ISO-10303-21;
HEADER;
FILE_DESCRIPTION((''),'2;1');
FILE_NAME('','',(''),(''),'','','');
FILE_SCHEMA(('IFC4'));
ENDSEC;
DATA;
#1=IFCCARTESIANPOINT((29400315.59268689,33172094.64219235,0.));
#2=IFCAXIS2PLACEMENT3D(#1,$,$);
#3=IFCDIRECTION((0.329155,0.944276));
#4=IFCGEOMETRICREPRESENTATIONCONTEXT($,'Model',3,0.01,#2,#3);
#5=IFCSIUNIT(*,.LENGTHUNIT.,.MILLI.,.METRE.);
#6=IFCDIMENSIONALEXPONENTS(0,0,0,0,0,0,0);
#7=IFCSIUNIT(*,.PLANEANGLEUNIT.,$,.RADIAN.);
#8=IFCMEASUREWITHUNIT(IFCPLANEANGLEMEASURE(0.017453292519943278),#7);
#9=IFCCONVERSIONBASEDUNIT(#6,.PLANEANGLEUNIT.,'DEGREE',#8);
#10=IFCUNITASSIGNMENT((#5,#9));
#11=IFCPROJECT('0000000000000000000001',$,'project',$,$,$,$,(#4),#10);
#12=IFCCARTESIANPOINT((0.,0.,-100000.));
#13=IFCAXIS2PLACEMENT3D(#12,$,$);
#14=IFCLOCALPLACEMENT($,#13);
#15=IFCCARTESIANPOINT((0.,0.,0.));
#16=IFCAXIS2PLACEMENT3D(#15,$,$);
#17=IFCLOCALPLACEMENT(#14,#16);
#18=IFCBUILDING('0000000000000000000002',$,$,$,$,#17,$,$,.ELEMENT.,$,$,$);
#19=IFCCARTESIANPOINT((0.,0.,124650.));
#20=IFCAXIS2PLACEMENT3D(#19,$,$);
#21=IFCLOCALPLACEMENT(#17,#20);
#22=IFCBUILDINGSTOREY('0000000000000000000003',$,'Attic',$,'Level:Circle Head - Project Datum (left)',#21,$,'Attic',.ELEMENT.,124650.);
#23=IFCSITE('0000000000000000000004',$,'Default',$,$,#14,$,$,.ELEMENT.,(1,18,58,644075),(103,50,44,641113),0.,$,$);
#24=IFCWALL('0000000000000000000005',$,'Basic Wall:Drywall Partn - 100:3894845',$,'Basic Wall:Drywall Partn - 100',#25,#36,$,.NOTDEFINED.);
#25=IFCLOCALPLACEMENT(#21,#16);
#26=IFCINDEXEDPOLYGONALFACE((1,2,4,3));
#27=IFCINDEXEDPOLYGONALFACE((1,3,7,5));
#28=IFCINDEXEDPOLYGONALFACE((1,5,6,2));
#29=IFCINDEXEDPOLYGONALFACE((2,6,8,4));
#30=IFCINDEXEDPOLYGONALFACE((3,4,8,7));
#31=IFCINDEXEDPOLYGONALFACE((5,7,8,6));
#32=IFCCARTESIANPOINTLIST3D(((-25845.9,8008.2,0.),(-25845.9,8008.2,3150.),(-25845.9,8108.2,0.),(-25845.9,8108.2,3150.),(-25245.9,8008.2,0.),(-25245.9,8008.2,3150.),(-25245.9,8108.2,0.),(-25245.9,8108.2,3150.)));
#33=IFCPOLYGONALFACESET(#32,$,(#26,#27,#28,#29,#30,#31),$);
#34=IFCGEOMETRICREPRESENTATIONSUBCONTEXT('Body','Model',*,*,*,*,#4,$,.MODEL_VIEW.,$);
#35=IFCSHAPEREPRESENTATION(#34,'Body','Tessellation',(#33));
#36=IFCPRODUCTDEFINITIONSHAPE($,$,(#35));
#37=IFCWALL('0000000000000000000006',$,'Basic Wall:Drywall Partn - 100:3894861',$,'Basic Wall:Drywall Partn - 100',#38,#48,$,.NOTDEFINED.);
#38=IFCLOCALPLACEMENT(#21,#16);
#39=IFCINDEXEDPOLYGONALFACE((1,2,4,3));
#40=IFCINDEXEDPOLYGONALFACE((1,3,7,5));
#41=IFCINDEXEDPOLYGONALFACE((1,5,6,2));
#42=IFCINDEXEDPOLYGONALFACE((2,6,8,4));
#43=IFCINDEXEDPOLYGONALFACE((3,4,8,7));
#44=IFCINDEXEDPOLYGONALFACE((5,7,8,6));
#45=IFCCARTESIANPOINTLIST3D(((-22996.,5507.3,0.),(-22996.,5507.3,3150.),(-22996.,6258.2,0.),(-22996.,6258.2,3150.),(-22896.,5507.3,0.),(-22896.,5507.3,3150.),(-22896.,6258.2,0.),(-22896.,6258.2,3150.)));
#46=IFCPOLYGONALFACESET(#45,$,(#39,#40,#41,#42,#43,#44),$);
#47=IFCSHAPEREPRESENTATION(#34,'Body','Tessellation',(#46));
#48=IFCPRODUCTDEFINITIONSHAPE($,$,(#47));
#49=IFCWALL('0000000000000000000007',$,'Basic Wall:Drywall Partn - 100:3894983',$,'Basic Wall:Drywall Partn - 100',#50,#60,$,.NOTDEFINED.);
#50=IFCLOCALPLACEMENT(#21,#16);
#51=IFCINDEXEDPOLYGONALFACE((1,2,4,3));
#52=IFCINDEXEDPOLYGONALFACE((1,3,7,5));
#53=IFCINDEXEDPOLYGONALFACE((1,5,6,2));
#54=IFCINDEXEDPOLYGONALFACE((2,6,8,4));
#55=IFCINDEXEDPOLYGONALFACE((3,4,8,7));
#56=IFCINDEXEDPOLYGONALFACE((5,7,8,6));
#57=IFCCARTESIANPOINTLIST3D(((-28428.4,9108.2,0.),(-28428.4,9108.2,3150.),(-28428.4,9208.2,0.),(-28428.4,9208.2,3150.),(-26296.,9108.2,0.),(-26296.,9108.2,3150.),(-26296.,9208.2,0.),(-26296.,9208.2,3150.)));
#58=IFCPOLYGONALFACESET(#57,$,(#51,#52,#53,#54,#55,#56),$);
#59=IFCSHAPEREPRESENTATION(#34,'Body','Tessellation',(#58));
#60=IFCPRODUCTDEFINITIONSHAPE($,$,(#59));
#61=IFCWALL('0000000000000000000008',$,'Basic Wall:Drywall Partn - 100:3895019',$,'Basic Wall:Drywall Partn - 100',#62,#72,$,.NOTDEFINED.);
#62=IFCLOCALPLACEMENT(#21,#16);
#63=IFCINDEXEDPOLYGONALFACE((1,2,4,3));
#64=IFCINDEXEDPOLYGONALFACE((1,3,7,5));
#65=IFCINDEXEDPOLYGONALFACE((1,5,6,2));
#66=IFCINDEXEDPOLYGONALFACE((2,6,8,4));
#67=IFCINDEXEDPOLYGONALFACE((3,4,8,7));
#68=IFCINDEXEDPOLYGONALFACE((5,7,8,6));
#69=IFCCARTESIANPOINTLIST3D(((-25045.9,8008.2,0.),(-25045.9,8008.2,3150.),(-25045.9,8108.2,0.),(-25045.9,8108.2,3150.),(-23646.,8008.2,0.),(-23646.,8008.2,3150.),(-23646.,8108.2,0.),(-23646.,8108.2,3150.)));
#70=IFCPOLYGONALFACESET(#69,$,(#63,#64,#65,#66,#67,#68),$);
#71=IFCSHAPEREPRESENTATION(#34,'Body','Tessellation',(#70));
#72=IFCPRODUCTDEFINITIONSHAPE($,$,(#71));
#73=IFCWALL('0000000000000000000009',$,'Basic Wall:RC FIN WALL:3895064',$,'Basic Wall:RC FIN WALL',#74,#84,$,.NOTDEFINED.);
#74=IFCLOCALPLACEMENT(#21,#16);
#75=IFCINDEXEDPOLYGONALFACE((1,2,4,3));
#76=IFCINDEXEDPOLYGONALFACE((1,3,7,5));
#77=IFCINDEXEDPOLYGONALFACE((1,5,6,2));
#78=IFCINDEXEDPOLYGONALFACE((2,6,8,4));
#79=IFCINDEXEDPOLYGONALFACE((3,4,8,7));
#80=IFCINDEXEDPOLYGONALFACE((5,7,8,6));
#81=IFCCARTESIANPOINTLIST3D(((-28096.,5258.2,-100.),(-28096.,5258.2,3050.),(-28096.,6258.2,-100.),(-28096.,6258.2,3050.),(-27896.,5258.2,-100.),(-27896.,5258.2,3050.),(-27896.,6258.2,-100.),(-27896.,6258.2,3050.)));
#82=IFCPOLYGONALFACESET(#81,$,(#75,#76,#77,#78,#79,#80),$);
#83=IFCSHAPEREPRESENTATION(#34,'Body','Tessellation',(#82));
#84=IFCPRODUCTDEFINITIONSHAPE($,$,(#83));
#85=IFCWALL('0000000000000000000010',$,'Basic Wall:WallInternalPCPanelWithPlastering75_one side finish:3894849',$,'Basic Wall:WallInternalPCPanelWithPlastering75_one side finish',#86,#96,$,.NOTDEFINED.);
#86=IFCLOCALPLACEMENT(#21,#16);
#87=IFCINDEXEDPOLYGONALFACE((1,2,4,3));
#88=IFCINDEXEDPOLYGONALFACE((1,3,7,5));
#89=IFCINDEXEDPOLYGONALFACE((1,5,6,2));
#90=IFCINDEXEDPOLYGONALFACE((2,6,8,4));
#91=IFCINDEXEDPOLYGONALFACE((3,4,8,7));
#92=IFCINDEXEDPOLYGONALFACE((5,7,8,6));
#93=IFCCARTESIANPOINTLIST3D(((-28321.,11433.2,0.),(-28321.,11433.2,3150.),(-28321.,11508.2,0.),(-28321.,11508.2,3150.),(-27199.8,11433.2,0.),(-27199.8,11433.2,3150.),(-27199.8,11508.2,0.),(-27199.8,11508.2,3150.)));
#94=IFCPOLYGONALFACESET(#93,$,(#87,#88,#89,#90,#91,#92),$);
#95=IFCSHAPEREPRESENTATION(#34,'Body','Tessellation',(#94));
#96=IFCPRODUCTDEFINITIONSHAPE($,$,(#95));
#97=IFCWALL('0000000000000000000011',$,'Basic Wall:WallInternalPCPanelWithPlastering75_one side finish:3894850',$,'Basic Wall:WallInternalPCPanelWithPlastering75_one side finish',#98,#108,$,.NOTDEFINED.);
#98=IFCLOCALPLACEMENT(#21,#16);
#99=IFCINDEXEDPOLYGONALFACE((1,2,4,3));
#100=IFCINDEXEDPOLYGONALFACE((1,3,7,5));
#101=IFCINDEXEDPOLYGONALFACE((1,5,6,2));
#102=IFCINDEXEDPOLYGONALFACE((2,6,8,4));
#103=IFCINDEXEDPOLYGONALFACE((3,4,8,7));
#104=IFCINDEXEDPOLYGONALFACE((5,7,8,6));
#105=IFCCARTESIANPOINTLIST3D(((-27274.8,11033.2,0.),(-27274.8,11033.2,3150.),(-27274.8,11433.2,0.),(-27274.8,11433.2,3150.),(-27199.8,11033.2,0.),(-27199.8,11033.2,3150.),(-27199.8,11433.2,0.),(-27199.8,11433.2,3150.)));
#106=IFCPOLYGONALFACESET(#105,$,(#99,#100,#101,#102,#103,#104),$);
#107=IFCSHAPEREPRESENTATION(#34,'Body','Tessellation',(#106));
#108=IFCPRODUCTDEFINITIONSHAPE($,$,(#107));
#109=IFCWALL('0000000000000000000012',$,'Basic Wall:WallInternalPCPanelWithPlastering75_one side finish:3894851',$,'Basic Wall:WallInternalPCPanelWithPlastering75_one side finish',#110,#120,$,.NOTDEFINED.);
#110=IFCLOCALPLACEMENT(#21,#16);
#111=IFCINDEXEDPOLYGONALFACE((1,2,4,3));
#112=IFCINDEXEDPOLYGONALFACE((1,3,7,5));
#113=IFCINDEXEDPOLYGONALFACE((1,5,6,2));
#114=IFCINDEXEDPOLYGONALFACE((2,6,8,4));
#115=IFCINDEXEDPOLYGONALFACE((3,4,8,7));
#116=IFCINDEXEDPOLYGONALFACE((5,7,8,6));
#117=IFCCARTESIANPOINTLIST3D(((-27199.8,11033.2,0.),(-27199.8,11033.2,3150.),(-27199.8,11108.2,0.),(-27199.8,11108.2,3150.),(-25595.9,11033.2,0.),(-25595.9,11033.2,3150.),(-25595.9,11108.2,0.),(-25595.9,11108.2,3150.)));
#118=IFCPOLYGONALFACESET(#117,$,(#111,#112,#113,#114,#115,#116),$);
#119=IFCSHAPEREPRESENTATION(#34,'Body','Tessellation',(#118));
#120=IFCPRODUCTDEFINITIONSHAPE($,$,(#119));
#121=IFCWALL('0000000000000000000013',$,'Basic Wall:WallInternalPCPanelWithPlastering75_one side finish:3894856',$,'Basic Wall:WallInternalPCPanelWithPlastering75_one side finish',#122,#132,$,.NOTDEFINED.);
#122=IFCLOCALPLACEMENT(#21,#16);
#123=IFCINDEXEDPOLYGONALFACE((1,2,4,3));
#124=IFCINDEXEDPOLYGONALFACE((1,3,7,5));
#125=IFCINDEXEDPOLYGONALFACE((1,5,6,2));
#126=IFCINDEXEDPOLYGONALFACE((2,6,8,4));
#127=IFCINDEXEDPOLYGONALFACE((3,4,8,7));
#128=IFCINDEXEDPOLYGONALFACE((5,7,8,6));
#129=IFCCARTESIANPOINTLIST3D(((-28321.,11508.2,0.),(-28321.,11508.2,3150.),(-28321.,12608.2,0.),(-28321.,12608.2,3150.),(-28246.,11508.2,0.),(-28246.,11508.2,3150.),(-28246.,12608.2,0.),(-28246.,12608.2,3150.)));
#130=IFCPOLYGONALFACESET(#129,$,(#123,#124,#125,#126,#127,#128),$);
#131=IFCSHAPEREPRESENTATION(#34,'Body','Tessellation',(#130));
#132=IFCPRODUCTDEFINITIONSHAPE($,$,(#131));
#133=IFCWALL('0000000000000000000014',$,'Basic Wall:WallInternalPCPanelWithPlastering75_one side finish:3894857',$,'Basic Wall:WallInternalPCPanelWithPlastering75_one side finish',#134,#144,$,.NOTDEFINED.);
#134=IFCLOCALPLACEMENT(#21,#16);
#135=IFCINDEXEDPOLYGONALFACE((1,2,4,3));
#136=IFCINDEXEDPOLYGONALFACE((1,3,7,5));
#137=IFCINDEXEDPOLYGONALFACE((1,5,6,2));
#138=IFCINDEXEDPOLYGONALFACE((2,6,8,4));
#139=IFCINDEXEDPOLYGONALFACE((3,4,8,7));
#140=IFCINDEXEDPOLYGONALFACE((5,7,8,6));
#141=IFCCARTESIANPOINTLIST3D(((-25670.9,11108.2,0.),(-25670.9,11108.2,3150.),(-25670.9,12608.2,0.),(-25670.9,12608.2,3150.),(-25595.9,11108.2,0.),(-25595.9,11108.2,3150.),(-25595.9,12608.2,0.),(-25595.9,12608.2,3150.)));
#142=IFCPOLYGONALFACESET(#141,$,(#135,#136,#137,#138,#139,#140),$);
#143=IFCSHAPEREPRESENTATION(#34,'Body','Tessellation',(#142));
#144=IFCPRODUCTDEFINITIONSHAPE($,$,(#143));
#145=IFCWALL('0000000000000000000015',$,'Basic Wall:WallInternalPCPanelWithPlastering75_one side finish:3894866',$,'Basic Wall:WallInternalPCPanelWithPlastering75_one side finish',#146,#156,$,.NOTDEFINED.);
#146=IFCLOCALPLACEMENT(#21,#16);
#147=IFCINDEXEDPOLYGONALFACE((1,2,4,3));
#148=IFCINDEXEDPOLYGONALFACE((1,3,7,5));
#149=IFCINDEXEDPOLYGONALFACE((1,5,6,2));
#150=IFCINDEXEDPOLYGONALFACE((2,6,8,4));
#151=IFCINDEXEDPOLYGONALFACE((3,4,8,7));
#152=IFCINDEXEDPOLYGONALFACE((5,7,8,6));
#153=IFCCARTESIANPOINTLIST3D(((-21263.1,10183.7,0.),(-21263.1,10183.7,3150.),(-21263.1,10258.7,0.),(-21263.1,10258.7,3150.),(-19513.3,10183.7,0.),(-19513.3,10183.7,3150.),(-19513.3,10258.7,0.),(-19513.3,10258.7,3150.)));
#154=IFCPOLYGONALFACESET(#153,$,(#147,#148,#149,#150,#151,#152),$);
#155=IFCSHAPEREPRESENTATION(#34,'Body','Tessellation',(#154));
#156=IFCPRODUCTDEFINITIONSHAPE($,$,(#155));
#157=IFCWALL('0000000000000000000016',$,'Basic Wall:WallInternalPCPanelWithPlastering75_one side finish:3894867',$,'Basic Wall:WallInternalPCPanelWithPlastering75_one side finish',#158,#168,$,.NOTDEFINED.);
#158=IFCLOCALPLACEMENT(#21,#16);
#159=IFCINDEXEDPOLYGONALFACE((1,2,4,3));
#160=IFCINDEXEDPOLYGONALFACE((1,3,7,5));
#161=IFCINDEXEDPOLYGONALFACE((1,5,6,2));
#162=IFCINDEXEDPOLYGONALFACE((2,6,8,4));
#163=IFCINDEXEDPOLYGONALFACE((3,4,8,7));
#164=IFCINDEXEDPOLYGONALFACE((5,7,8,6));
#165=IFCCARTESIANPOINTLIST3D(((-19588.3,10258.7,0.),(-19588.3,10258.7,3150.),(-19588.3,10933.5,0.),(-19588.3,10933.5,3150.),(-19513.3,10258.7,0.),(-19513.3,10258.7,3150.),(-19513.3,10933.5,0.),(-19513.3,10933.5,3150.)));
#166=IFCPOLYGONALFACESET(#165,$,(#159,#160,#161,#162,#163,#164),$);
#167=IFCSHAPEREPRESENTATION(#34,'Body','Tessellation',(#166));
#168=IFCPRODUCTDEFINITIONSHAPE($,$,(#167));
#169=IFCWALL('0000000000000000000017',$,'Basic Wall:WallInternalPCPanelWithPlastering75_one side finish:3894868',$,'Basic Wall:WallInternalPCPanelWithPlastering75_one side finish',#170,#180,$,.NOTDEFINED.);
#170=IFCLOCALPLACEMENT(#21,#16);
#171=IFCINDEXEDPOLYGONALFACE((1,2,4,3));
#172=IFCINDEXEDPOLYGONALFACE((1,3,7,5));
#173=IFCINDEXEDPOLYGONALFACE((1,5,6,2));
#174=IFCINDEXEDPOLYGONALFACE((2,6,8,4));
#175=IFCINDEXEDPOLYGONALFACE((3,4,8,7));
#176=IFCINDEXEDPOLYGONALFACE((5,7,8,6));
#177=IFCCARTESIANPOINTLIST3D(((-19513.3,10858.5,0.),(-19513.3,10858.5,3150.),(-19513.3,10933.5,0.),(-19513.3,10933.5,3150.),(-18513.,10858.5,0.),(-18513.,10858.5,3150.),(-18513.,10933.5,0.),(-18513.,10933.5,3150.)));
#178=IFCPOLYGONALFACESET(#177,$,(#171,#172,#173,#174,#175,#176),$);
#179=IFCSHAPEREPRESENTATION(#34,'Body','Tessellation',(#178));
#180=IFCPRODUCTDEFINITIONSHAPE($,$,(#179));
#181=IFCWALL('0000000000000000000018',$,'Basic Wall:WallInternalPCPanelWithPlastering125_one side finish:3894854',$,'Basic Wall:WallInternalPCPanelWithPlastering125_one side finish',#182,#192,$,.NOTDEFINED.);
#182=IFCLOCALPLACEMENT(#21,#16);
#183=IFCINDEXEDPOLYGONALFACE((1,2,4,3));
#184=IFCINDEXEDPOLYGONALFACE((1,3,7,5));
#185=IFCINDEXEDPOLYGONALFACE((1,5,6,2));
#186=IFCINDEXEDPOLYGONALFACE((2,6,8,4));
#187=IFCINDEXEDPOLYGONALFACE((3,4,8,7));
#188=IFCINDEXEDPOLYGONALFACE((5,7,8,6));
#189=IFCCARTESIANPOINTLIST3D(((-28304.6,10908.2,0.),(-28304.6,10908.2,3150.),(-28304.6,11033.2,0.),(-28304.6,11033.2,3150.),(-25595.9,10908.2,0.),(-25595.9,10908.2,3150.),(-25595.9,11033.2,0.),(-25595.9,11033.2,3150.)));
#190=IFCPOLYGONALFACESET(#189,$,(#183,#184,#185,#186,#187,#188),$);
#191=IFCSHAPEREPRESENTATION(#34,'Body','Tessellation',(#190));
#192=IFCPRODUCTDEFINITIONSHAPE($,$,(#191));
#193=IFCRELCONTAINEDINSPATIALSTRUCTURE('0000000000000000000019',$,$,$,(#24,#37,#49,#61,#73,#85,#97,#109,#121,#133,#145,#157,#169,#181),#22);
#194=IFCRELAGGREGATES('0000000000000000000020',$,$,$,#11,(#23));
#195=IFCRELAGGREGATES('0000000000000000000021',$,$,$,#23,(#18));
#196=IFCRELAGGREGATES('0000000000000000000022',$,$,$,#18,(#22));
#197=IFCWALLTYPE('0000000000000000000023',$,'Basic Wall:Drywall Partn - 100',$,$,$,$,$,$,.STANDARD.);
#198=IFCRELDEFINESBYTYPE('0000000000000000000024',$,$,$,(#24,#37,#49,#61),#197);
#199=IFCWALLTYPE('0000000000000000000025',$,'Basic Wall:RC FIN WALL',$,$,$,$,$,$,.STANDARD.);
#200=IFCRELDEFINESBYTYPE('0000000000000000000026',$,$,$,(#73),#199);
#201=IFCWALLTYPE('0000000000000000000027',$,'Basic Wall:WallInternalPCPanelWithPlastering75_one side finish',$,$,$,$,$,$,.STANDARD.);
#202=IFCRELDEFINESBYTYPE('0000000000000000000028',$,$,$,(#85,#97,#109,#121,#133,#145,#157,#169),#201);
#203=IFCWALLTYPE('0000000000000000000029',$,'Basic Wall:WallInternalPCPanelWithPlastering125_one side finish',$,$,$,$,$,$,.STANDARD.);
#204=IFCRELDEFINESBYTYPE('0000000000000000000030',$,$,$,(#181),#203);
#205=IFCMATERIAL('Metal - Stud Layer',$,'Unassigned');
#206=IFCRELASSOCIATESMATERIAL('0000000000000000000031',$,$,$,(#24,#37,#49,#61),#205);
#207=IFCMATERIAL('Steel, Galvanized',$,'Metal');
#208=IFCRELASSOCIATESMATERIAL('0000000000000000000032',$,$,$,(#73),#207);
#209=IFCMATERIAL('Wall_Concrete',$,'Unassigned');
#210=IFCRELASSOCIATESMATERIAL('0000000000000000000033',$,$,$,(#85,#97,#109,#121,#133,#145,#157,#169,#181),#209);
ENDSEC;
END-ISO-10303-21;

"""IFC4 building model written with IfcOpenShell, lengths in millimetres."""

from ifc_helpers import new_model, entity, si_unit, converted_unit, direction, frame, origin, place, context, subcontext, project, spatial, indexed_curve, outline, extrude, material, type_object, element, save


model = new_model("IFC4")

# Units and contexts
model_context = context("Model", 3, precision=0.01, world=frame((29400315.59268689, 33172094.64219235, 0.0)), true_north=direction((0.329155, 0.944276)))
body_context = subcontext(model_context, "Body", "Model", "MODEL_VIEW")
ifc_project = project(units=[si_unit("LENGTHUNIT", "METRE", prefix="MILLI"), converted_unit("PLANEANGLEUNIT", "DEGREE", entity("IfcPlaneAngleMeasure", 0.017453292519943278), si_unit("PLANEANGLEUNIT", "RADIAN"), dimensions=[0, 0, 0, 0, 0, 0, 0])], contexts=[model_context])

# Site, building, storey
site_placement = place(None, frame((0.0, 0.0, -100000.0)))
site = spatial("IfcSite", under=ifc_project, at=site_placement, Name="Default", CompositionType="ELEMENT", RefLatitude=(1, 18, 58, 644075), RefLongitude=(103, 50, 44, 641113), RefElevation=0.0)
building_placement = place(site_placement, origin())
building = spatial("IfcBuilding", under=site, at=building_placement, CompositionType="ELEMENT")
storey_placement = place(building_placement, frame((0.0, 0.0, 124650.0)))
storey = spatial("IfcBuildingStorey", under=building, at=storey_placement, Name="Attic", ObjectType="Level:Circle Head - Project Datum (left)", LongName="Attic", CompositionType="ELEMENT", Elevation=124650.0)

# Walls
ifc_material_1 = material(Name="Metal - Stud Layer", Category="Unassigned")
wall_type_1 = type_object("IfcWallType", Name="Basic Wall:Drywall Partn - 100", PredefinedType="STANDARD")
wall_1_placement = place(storey_placement, frame((-25845.9, 8058.2, 0.0)))
element("IfcWall", 1, at=wall_1_placement, inside=storey, type_object=wall_type_1, material=ifc_material_1, Name="Basic Wall:Drywall Partn - 100:3894845", ObjectType="Basic Wall:Drywall Partn - 100", PredefinedType="NOTDEFINED", context=body_context, shape_type="SweptSolid", body=[
    extrude(outline(indexed_curve([(600.0, 50.0), (0.0, 50.0), (0.0, -50.0), (600.0, -50.0), (600.0, 50.0)], self_intersect=False)), origin(), (0.0, 0.0, 1.0), 3150.0),
])
wall_2_placement = place(storey_placement, frame((-22946.0, 6258.2, 0.0), z_axis=(0.0, 0.0, 1.0), x_axis=(0.0, -1.0, 0.0)))
element("IfcWall", 2, at=wall_2_placement, inside=storey, type_object=wall_type_1, material=ifc_material_1, Name="Basic Wall:Drywall Partn - 100:3894861", ObjectType="Basic Wall:Drywall Partn - 100", PredefinedType="NOTDEFINED", context=body_context, shape_type="SweptSolid", body=[
    extrude(outline(indexed_curve([(751.0, 50.0), (0.0, 50.0), (0.0, -50.0), (751.0, -50.0), (751.0, 50.0)], self_intersect=False)), origin(), (0.0, 0.0, 1.0), 3150.0),
])
wall_3_placement = place(storey_placement, frame((-26296.0, 9158.2, 0.0), z_axis=(0.0, 0.0, 1.0), x_axis=(-1.0, 0.0, 0.0)))
element("IfcWall", 3, at=wall_3_placement, inside=storey, type_object=wall_type_1, material=ifc_material_1, Name="Basic Wall:Drywall Partn - 100:3894983", ObjectType="Basic Wall:Drywall Partn - 100", PredefinedType="NOTDEFINED", context=body_context, shape_type="SweptSolid", body=[
    extrude(outline(indexed_curve([(2132.4, 50.0), (0.0, 50.0), (0.0, -50.0), (2132.4, -50.0), (2132.4, 50.0)], self_intersect=False)), origin(), (0.0, 0.0, 1.0), 3150.0),
])
wall_4_placement = place(storey_placement, frame((-25045.9, 8058.2, 0.0)))
element("IfcWall", 4, at=wall_4_placement, inside=storey, type_object=wall_type_1, material=ifc_material_1, Name="Basic Wall:Drywall Partn - 100:3895019", ObjectType="Basic Wall:Drywall Partn - 100", PredefinedType="NOTDEFINED", context=body_context, shape_type="SweptSolid", body=[
    extrude(outline(indexed_curve([(1399.9, 50.0), (0.0, 50.0), (0.0, -50.0), (1399.9, -50.0), (1399.9, 50.0)], self_intersect=False)), origin(), (0.0, 0.0, 1.0), 3150.0),
])
ifc_material_2 = material(Name="Steel, Galvanized", Category="Metal")
wall_type_2 = type_object("IfcWallType", Name="Basic Wall:RC FIN WALL", PredefinedType="STANDARD")
wall_5_placement = place(storey_placement, frame((-27996.0, 6258.2, -100.0), z_axis=(0.0, 0.0, 1.0), x_axis=(0.0, -1.0, 0.0)))
element("IfcWall", 5, at=wall_5_placement, inside=storey, type_object=wall_type_2, material=ifc_material_2, Name="Basic Wall:RC FIN WALL:3895064", ObjectType="Basic Wall:RC FIN WALL", PredefinedType="NOTDEFINED", context=body_context, shape_type="SweptSolid", body=[
    extrude(outline(indexed_curve([(1000.0, 100.0), (0.0, 100.0), (0.0, -100.0), (1000.0, -100.0), (1000.0, 100.0)], self_intersect=False)), origin(), (0.0, 0.0, 1.0), 3150.0),
])
ifc_material_3 = material(Name="Wall_Concrete", Category="Unassigned")
wall_type_3 = type_object("IfcWallType", Name="Basic Wall:WallInternalPCPanelWithPlastering75_one side finish", PredefinedType="STANDARD")
wall_6_placement = place(storey_placement, frame((-28321.0, 11470.7, 0.0)))
element("IfcWall", 6, at=wall_6_placement, inside=storey, type_object=wall_type_3, material=ifc_material_3, Name="Basic Wall:WallInternalPCPanelWithPlastering75_one side finish:3894849", ObjectType="Basic Wall:WallInternalPCPanelWithPlastering75_one side finish", PredefinedType="NOTDEFINED", context=body_context, shape_type="SweptSolid", body=[
    extrude(outline(indexed_curve([(1121.2, 37.5), (0.0, 37.5), (0.0, -37.5), (1121.2, -37.5), (1121.2, 37.5)], self_intersect=False)), origin(), (0.0, 0.0, 1.0), 3150.0),
])
wall_7_placement = place(storey_placement, frame((-27237.3, 11433.2, 0.0), z_axis=(0.0, 0.0, 1.0), x_axis=(0.0, -1.0, 0.0)))
element("IfcWall", 7, at=wall_7_placement, inside=storey, type_object=wall_type_3, material=ifc_material_3, Name="Basic Wall:WallInternalPCPanelWithPlastering75_one side finish:3894850", ObjectType="Basic Wall:WallInternalPCPanelWithPlastering75_one side finish", PredefinedType="NOTDEFINED", context=body_context, shape_type="SweptSolid", body=[
    extrude(outline(indexed_curve([(400.0, 37.5), (0.0, 37.5), (0.0, -37.5), (400.0, -37.5), (400.0, 37.5)], self_intersect=False)), origin(), (0.0, 0.0, 1.0), 3150.0),
])
wall_8_placement = place(storey_placement, frame((-27199.8, 11070.7, 0.0)))
element("IfcWall", 8, at=wall_8_placement, inside=storey, type_object=wall_type_3, material=ifc_material_3, Name="Basic Wall:WallInternalPCPanelWithPlastering75_one side finish:3894851", ObjectType="Basic Wall:WallInternalPCPanelWithPlastering75_one side finish", PredefinedType="NOTDEFINED", context=body_context, shape_type="SweptSolid", body=[
    extrude(outline(indexed_curve([(1603.9, 37.5), (0.0, 37.5), (0.0, -37.5), (1603.9, -37.5), (1603.9, 37.5)], self_intersect=False)), origin(), (0.0, 0.0, 1.0), 3150.0),
])
wall_9_placement = place(storey_placement, frame((-28283.5, 12608.2, 0.0), z_axis=(0.0, 0.0, 1.0), x_axis=(0.0, -1.0, 0.0)))
element("IfcWall", 9, at=wall_9_placement, inside=storey, type_object=wall_type_3, material=ifc_material_3, Name="Basic Wall:WallInternalPCPanelWithPlastering75_one side finish:3894856", ObjectType="Basic Wall:WallInternalPCPanelWithPlastering75_one side finish", PredefinedType="NOTDEFINED", context=body_context, shape_type="SweptSolid", body=[
    extrude(outline(indexed_curve([(1100.0, 37.5), (0.0, 37.5), (0.0, -37.5), (1100.0, -37.5), (1100.0, 37.5)], self_intersect=False)), origin(), (0.0, 0.0, 1.0), 3150.0),
])
wall_10_placement = place(storey_placement, frame((-25633.4, 11108.2, 0.0), z_axis=(0.0, 0.0, 1.0), x_axis=(0.0, 1.0, 0.0)))
element("IfcWall", 10, at=wall_10_placement, inside=storey, type_object=wall_type_3, material=ifc_material_3, Name="Basic Wall:WallInternalPCPanelWithPlastering75_one side finish:3894857", ObjectType="Basic Wall:WallInternalPCPanelWithPlastering75_one side finish", PredefinedType="NOTDEFINED", context=body_context, shape_type="SweptSolid", body=[
    extrude(outline(indexed_curve([(1500.1, 37.5), (0.0, 37.5), (0.0, -37.5), (1500.1, -37.5), (1500.1, 37.5)], self_intersect=False)), origin(), (0.0, 0.0, 1.0), 3150.0),
])
wall_11_placement = place(storey_placement, frame((-21263.1, 10221.2, 0.0)))
element("IfcWall", 11, at=wall_11_placement, inside=storey, type_object=wall_type_3, material=ifc_material_3, Name="Basic Wall:WallInternalPCPanelWithPlastering75_one side finish:3894866", ObjectType="Basic Wall:WallInternalPCPanelWithPlastering75_one side finish", PredefinedType="NOTDEFINED", context=body_context, shape_type="SweptSolid", body=[
    extrude(outline(indexed_curve([(1749.7, 37.5), (0.0, 37.5), (0.0, -37.5), (1749.7, -37.5), (1749.7, 37.5)], self_intersect=False)), origin(), (0.0, 0.0, 1.0), 3150.0),
])
wall_12_placement = place(storey_placement, frame((-19550.8, 10258.7, 0.0), z_axis=(0.0, 0.0, 1.0), x_axis=(0.0, 1.0, 0.0)))
element("IfcWall", 12, at=wall_12_placement, inside=storey, type_object=wall_type_3, material=ifc_material_3, Name="Basic Wall:WallInternalPCPanelWithPlastering75_one side finish:3894867", ObjectType="Basic Wall:WallInternalPCPanelWithPlastering75_one side finish", PredefinedType="NOTDEFINED", context=body_context, shape_type="SweptSolid", body=[
    extrude(outline(indexed_curve([(674.8, 37.5), (0.0, 37.5), (0.0, -37.5), (674.8, -37.5), (674.8, 37.5)], self_intersect=False)), origin(), (0.0, 0.0, 1.0), 3150.0),
])
wall_13_placement = place(storey_placement, frame((-19513.3, 10896.0, 0.0)))
element("IfcWall", 13, at=wall_13_placement, inside=storey, type_object=wall_type_3, material=ifc_material_3, Name="Basic Wall:WallInternalPCPanelWithPlastering75_one side finish:3894868", ObjectType="Basic Wall:WallInternalPCPanelWithPlastering75_one side finish", PredefinedType="NOTDEFINED", context=body_context, shape_type="SweptSolid", body=[
    extrude(outline(indexed_curve([(1000.3, 37.5), (0.0, 37.5), (0.0, -37.5), (1000.3, -37.5), (1000.3, 37.5)], self_intersect=False)), origin(), (0.0, 0.0, 1.0), 3150.0),
])
wall_type_4 = type_object("IfcWallType", Name="Basic Wall:WallInternalPCPanelWithPlastering125_one side finish", PredefinedType="STANDARD")
wall_14_placement = place(storey_placement, frame((-28304.6, 10970.7, 0.0)))
element("IfcWall", 14, at=wall_14_placement, inside=storey, type_object=wall_type_4, material=ifc_material_3, Name="Basic Wall:WallInternalPCPanelWithPlastering125_one side finish:3894854", ObjectType="Basic Wall:WallInternalPCPanelWithPlastering125_one side finish", PredefinedType="NOTDEFINED", context=body_context, shape_type="SweptSolid", body=[
    extrude(outline(indexed_curve([(2708.7, 62.5), (0.0, 62.5), (0.0, -62.5), (2708.7, -62.5), (2708.7, 62.5)], self_intersect=False)), origin(), (0.0, 0.0, 1.0), 3150.0),
])

save(model, "model.ifc")
